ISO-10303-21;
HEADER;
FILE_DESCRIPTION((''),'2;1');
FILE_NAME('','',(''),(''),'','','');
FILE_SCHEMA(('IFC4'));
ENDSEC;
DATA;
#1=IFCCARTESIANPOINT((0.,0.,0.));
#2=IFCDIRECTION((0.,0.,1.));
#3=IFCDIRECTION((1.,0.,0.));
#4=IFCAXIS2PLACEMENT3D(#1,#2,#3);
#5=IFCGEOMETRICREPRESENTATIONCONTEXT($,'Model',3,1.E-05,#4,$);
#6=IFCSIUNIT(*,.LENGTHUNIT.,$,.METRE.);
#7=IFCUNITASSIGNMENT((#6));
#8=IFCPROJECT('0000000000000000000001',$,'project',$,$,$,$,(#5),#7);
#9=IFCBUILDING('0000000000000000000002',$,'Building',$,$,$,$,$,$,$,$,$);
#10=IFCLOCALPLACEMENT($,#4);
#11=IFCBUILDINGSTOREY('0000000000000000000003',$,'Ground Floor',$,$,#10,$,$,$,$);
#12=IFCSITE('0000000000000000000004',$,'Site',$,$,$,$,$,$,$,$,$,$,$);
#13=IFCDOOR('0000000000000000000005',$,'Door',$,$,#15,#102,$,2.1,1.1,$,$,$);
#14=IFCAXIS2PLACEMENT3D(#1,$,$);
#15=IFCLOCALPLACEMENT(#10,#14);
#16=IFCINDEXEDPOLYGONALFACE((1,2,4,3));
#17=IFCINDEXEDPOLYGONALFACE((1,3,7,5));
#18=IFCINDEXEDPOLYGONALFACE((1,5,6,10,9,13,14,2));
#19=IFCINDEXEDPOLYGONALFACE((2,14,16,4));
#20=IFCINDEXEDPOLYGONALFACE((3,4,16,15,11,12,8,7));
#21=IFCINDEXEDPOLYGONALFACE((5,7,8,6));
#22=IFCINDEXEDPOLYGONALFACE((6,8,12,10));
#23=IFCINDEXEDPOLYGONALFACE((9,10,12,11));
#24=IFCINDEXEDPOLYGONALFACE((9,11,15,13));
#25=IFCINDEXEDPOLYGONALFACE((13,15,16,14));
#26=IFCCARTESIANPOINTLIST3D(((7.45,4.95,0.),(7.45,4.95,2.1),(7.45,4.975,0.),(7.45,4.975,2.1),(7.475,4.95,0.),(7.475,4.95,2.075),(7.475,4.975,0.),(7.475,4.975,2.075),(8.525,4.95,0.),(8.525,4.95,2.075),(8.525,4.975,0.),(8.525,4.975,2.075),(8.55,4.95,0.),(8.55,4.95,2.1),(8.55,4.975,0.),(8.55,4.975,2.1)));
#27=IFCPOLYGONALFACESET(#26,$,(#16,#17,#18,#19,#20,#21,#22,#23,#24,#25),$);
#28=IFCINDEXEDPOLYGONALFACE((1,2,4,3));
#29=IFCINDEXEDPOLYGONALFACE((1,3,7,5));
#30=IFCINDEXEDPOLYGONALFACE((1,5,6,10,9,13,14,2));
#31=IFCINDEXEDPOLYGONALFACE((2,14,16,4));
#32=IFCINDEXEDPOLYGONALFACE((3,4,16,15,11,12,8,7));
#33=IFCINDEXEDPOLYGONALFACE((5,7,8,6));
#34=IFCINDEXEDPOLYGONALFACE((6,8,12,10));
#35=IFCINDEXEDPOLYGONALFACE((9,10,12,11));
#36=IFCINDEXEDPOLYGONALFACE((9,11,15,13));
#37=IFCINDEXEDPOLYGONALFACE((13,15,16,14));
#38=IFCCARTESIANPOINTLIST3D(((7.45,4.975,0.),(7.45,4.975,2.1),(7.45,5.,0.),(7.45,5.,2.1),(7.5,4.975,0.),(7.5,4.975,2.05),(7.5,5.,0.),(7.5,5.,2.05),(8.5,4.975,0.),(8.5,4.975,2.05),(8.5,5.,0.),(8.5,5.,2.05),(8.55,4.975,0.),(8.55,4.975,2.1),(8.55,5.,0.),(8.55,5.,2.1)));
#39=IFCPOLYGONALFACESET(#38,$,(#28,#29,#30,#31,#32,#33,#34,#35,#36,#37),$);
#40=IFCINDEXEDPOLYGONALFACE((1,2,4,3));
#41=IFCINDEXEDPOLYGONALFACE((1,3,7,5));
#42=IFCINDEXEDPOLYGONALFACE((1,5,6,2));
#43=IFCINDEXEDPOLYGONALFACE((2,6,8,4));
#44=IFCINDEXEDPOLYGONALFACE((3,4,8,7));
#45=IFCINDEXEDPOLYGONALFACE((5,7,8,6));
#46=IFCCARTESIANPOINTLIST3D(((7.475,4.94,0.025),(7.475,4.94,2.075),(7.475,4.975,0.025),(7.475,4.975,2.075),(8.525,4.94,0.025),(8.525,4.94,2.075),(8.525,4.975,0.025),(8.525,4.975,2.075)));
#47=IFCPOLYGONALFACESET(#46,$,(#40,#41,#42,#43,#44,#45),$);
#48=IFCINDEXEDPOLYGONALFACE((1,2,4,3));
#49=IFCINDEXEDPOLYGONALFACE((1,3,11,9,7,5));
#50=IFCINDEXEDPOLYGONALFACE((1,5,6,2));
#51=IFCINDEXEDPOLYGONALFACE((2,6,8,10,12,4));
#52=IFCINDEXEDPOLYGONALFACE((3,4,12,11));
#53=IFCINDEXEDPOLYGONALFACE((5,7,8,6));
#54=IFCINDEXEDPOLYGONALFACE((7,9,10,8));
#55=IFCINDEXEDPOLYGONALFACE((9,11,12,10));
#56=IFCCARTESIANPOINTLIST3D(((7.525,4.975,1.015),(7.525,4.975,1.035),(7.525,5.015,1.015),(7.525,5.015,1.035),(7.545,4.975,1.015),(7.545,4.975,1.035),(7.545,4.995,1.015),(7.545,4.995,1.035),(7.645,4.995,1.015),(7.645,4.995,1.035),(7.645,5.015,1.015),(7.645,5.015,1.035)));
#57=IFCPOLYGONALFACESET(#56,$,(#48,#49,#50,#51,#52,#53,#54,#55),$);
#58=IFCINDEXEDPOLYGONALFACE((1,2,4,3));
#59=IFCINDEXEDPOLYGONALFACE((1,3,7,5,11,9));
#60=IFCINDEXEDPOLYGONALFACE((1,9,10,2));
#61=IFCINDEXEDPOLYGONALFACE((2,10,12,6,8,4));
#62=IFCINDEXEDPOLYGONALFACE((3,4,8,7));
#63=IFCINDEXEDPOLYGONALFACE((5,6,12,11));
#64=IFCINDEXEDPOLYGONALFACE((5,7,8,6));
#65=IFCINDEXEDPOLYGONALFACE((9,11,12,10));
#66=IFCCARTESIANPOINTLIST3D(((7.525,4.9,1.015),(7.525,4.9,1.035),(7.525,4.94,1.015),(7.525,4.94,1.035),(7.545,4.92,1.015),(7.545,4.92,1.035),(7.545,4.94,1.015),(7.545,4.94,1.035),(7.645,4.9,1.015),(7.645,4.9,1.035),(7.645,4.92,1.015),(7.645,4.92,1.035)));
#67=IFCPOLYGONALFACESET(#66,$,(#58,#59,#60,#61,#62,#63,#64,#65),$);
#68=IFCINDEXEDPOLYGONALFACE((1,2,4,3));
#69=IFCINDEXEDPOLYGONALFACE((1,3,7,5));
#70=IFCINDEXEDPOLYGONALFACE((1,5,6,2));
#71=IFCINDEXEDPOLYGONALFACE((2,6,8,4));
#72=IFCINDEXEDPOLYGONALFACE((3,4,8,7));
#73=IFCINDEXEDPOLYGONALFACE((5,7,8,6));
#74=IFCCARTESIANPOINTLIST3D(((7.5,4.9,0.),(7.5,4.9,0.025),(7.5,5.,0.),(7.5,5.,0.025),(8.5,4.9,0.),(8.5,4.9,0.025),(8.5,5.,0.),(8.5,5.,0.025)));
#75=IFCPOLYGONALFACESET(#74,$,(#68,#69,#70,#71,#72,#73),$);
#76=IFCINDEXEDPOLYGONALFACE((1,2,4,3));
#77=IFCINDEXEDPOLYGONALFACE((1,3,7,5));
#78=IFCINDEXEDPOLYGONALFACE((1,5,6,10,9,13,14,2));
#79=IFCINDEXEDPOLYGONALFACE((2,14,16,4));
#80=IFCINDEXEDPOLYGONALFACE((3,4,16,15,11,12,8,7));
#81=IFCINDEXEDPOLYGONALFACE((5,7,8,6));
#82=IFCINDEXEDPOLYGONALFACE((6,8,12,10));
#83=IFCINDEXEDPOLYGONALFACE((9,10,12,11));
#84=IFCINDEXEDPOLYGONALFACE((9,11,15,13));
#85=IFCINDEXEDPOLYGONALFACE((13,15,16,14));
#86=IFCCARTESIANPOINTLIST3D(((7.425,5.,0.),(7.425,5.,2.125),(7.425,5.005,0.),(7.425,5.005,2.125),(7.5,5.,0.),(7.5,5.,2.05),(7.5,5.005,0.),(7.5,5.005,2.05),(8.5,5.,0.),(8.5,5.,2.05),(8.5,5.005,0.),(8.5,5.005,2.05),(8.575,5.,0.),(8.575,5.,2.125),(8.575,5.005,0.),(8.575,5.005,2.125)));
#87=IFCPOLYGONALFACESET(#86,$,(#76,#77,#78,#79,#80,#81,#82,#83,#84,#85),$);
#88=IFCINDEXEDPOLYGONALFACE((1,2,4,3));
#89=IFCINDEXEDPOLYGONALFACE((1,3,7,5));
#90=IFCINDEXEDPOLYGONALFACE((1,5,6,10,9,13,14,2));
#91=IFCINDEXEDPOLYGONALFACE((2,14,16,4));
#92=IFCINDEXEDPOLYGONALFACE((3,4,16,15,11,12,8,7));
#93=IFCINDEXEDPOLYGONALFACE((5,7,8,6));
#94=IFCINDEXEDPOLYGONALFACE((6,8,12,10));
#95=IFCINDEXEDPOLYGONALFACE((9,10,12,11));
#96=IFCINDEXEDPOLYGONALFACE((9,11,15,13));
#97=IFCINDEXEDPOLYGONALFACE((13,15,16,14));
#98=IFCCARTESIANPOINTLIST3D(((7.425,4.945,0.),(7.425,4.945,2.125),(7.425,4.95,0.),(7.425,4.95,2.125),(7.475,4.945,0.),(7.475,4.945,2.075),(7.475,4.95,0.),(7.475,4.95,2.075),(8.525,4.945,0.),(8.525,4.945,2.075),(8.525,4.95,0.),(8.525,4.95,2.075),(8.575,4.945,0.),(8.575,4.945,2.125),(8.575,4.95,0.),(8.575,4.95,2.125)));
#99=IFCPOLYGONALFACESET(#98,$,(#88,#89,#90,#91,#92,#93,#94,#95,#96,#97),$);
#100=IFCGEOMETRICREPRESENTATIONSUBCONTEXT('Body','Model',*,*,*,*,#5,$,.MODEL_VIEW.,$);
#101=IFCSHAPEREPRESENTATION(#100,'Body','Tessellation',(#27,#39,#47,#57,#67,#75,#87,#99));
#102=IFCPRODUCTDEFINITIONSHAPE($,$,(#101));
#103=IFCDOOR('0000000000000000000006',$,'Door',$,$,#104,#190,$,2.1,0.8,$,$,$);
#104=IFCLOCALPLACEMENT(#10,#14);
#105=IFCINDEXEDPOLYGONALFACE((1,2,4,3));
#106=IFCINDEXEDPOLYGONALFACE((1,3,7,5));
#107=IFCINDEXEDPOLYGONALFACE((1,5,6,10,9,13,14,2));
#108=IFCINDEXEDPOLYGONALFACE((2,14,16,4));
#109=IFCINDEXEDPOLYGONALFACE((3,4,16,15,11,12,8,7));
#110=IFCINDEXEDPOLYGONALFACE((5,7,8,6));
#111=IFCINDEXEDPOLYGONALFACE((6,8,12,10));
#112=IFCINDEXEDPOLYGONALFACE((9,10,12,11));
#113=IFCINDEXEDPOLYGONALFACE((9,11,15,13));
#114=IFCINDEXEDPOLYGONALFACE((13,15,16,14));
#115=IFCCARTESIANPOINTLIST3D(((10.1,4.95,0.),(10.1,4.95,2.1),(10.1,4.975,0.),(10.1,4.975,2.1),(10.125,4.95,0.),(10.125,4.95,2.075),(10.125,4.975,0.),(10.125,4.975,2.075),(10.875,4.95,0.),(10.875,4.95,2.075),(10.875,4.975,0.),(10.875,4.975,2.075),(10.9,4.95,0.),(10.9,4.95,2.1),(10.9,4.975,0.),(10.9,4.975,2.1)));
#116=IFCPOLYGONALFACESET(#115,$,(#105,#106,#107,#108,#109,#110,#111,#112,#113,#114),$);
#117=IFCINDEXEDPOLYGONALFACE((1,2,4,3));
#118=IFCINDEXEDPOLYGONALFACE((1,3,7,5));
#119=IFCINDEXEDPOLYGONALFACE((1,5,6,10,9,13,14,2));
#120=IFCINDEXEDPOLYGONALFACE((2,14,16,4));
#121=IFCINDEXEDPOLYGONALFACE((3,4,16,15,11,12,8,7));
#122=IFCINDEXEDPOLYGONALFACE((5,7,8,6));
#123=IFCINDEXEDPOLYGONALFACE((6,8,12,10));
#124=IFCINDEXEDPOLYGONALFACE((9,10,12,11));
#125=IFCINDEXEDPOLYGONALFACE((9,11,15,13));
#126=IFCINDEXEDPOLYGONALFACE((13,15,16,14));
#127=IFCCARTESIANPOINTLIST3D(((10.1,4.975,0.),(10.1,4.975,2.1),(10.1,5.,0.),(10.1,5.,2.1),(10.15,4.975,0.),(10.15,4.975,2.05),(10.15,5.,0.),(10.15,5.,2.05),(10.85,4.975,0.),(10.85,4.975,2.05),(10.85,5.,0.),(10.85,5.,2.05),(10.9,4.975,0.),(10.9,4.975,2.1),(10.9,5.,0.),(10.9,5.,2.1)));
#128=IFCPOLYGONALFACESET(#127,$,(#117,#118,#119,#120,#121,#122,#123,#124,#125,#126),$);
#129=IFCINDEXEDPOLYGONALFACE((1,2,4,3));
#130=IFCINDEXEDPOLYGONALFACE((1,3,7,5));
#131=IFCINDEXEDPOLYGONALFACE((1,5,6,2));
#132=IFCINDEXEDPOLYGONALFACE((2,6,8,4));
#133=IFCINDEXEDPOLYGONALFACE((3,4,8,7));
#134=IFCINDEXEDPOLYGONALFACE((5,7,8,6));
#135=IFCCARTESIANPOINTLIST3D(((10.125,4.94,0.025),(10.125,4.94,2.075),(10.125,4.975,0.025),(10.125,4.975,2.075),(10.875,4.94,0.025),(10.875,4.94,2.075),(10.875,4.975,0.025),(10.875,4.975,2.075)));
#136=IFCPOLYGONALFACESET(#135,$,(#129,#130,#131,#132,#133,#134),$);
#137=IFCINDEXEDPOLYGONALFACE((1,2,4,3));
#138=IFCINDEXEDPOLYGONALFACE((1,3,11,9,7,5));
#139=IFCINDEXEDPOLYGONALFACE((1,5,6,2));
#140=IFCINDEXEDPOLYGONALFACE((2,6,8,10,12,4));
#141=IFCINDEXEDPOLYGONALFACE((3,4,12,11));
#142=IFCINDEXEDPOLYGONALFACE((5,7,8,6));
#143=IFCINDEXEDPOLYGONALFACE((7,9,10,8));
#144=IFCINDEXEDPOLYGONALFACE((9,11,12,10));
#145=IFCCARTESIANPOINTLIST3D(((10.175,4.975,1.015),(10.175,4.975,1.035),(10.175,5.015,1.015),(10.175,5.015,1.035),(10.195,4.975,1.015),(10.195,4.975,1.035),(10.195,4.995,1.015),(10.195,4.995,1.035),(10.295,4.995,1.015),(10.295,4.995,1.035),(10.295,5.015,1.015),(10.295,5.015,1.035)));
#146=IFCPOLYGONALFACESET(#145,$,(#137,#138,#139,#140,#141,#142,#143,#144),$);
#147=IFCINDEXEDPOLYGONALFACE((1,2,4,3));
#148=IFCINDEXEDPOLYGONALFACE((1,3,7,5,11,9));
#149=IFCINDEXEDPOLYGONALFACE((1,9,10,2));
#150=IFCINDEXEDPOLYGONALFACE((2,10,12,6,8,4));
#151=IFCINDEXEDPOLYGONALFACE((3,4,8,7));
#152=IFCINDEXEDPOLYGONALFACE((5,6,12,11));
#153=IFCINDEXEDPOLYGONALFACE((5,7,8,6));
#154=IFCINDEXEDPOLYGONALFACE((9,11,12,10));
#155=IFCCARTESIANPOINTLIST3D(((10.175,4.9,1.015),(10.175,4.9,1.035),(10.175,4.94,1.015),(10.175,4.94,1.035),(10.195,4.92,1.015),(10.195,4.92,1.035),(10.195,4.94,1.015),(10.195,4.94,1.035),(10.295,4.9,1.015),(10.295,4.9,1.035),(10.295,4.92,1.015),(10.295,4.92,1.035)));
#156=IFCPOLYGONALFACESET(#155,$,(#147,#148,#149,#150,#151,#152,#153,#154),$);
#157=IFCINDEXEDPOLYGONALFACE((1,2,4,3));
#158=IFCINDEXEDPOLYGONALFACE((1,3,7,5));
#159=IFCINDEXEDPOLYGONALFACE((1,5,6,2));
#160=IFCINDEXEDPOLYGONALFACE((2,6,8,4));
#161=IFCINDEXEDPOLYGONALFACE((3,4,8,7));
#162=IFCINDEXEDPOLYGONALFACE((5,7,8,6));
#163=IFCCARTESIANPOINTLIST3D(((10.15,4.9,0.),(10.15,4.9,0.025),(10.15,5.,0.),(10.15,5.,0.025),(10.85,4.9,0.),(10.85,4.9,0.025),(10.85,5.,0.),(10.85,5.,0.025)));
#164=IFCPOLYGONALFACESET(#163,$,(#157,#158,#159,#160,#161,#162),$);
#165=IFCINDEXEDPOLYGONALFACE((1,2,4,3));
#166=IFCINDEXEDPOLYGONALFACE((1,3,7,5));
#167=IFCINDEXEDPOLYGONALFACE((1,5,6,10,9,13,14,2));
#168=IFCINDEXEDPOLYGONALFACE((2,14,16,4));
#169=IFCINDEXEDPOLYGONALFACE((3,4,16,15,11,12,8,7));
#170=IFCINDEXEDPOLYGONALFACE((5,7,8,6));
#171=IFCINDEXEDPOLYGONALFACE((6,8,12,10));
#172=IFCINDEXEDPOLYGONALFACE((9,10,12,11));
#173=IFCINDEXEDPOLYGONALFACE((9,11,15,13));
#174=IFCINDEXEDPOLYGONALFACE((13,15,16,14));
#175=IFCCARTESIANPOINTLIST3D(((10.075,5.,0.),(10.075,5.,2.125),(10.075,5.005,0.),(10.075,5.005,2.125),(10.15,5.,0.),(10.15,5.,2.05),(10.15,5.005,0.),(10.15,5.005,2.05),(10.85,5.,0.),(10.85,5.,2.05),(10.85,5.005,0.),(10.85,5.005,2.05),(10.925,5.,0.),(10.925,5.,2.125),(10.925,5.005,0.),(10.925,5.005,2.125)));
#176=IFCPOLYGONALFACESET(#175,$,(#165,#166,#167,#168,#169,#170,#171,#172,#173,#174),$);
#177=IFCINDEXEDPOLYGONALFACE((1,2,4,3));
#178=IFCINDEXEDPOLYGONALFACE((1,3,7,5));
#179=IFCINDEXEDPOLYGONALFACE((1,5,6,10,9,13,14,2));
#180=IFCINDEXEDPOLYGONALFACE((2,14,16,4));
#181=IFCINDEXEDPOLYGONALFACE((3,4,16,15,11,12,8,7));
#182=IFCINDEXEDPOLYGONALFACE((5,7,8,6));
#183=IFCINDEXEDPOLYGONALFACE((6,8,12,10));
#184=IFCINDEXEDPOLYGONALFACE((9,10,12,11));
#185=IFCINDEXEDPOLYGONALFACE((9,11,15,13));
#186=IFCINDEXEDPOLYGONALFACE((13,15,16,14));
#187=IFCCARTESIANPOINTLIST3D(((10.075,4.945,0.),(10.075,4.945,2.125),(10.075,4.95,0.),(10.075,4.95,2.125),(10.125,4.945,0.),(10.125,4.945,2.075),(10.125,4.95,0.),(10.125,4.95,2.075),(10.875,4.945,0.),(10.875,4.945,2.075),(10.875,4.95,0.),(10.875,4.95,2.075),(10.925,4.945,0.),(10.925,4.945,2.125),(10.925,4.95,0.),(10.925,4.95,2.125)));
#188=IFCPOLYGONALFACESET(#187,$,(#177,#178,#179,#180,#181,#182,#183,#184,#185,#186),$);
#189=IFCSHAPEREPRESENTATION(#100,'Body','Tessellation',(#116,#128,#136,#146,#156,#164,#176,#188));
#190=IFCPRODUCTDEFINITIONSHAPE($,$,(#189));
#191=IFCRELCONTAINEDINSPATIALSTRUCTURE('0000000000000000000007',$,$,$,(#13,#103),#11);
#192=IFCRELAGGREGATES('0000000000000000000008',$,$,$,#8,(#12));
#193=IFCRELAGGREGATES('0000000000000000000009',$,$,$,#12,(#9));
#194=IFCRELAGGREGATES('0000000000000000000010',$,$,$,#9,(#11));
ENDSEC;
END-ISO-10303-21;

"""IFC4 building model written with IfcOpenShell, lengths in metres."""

from ifc_helpers import new_model, si_unit, frame, origin_with_axes, place, context, subcontext, project, spatial, line, indexed_curve, outline, extrude, element, save


model = new_model("IFC4")

# Units and contexts
model_context = context("Model", 3, precision=1e-05, world=origin_with_axes())
body_context = subcontext(model_context, "Body", "Model", "MODEL_VIEW")
ifc_project = project(units=[si_unit("LENGTHUNIT", "METRE")], contexts=[model_context])

# Site, building, storey
site = spatial("IfcSite", under=ifc_project, Name="Site")
building = spatial("IfcBuilding", under=site, Name="Building")
storey_placement = place(None, origin_with_axes())
storey = spatial("IfcBuildingStorey", under=building, at=storey_placement, Name="Ground Floor")

# Doors
door_1_placement = place(storey_placement, frame((8.55, 5.0, 0.0), z_axis=(0.0, 0.0, 1.0), x_axis=(-1.0, 0.0, 0.0)))
element("IfcDoor", 1, at=door_1_placement, inside=storey, Name="Door", OverallHeight=2.1, OverallWidth=1.1, context=body_context, shape_type="SweptSolid", body=[
    extrude(outline(indexed_curve([(0.0, 0.0), (0.0, 2.1), (1.1, 2.1), (1.1, 0.0), (1.075, 0.0), (1.075, 2.075), (0.025, 2.075), (0.025, 0.0)], segments=[line(1, 2, 3, 4, 5, 6, 7, 8, 1)])), frame((0.0, 0.025, 0.0), z_axis=(0.0, -1.0, 0.0), x_axis=(1.0, 0.0, 0.0)), (0.0, 0.0, -1.0), 0.025),
    extrude(outline(indexed_curve([(0.0, 0.0), (0.0, 2.1), (1.1, 2.1), (1.1, 0.0), (1.05, 0.0), (1.05, 2.05), (0.05, 2.05), (0.05, 0.0)], segments=[line(1, 2, 3, 4, 5, 6, 7, 8, 1)])), frame((0.0, 0.0, 0.0), z_axis=(0.0, -1.0, 0.0), x_axis=(1.0, 0.0, 0.0)), (0.0, 0.0, -1.0), 0.025),
    extrude(outline(indexed_curve([(0.0, 0.0), (1.05, 0.0), (1.05, 0.035), (0.0, 0.035)], segments=[line(1, 2, 3, 4, 1)])), frame((0.025, 0.025, 0.025), z_axis=(0.0, 0.0, 1.0), x_axis=(1.0, 0.0, 0.0)), (0.0, 0.0, 1.0), 2.05),
    extrude(outline(indexed_curve([(0.0, 0.0), (0.0, -0.04), (-0.12, -0.04), (-0.12, -0.02), (-0.02, -0.02), (-0.02, 0.0)], segments=[line(1, 2, 3, 4, 5, 6, 1)])), frame((1.025, 0.025, 1.015), z_axis=(0.0, 0.0, 1.0), x_axis=(1.0, 0.0, 0.0)), (0.0, 0.0, 1.0), 0.02),
    extrude(outline(indexed_curve([(0.0, 0.0), (0.0, 0.04), (-0.12, 0.04), (-0.12, 0.02), (-0.02, 0.02), (-0.02, 0.0)], segments=[line(1, 2, 3, 4, 5, 6, 1)])), frame((1.025, 0.06, 1.015), z_axis=(0.0, 0.0, 1.0), x_axis=(1.0, 0.0, 0.0)), (0.0, 0.0, 1.0), 0.02),
    extrude(outline(indexed_curve([(0.0, 0.0), (1.0, 0.0), (1.0, 0.1), (0.0, 0.1)], segments=[line(1, 2, 3, 4, 1)])), frame((0.05, 0.0, 0.0), z_axis=(0.0, 0.0, 1.0), x_axis=(1.0, 0.0, 0.0)), (0.0, 0.0, 1.0), 0.025),
    extrude(outline(indexed_curve([(0.0, 0.0), (0.0, 2.125), (1.15, 2.125), (1.15, 0.0), (1.075, 0.0), (1.075, 2.05), (0.075, 2.05), (0.075, 0.0)], segments=[line(1, 2, 3, 4, 5, 6, 7, 8, 1)])), frame((-0.025, -0.005, 0.0), z_axis=(0.0, -1.0, 0.0), x_axis=(1.0, 0.0, 0.0)), (0.0, 0.0, -1.0), 0.005),
    extrude(outline(indexed_curve([(0.0, 0.0), (0.0, 2.125), (1.15, 2.125), (1.15, 0.0), (1.1, 0.0), (1.1, 2.075), (0.05, 2.075), (0.05, 0.0)], segments=[line(1, 2, 3, 4, 5, 6, 7, 8, 1)])), frame((-0.025, 0.05, 0.0), z_axis=(0.0, -1.0, 0.0), x_axis=(1.0, 0.0, 0.0)), (0.0, 0.0, -1.0), 0.005),
])
door_2_placement = place(storey_placement, frame((10.9, 5.0, 0.0), z_axis=(0.0, 0.0, 1.0), x_axis=(-1.0, 0.0, 0.0)))
element("IfcDoor", 2, at=door_2_placement, inside=storey, Name="Door", OverallHeight=2.1, OverallWidth=0.8, context=body_context, shape_type="SweptSolid", body=[
    extrude(outline(indexed_curve([(0.0, 0.0), (0.0, 2.1), (0.8, 2.1), (0.8, 0.0), (0.775, 0.0), (0.775, 2.075), (0.025, 2.075), (0.025, 0.0)], segments=[line(1, 2, 3, 4, 5, 6, 7, 8, 1)])), frame((0.0, 0.025, 0.0), z_axis=(0.0, -1.0, 0.0), x_axis=(1.0, 0.0, 0.0)), (0.0, 0.0, -1.0), 0.025),
    extrude(outline(indexed_curve([(0.0, 0.0), (0.0, 2.1), (0.8, 2.1), (0.8, 0.0), (0.75, 0.0), (0.75, 2.05), (0.05, 2.05), (0.05, 0.0)], segments=[line(1, 2, 3, 4, 5, 6, 7, 8, 1)])), frame((0.0, 0.0, 0.0), z_axis=(0.0, -1.0, 0.0), x_axis=(1.0, 0.0, 0.0)), (0.0, 0.0, -1.0), 0.025),
    extrude(outline(indexed_curve([(0.0, 0.0), (0.75, 0.0), (0.75, 0.035), (0.0, 0.035)], segments=[line(1, 2, 3, 4, 1)])), frame((0.025, 0.025, 0.025), z_axis=(0.0, 0.0, 1.0), x_axis=(1.0, 0.0, 0.0)), (0.0, 0.0, 1.0), 2.05),
    extrude(outline(indexed_curve([(0.0, 0.0), (0.0, -0.04), (-0.12, -0.04), (-0.12, -0.02), (-0.02, -0.02), (-0.02, 0.0)], segments=[line(1, 2, 3, 4, 5, 6, 1)])), frame((0.725, 0.025, 1.015), z_axis=(0.0, 0.0, 1.0), x_axis=(1.0, 0.0, 0.0)), (0.0, 0.0, 1.0), 0.02),
    extrude(outline(indexed_curve([(0.0, 0.0), (0.0, 0.04), (-0.12, 0.04), (-0.12, 0.02), (-0.02, 0.02), (-0.02, 0.0)], segments=[line(1, 2, 3, 4, 5, 6, 1)])), frame((0.725, 0.06, 1.015), z_axis=(0.0, 0.0, 1.0), x_axis=(1.0, 0.0, 0.0)), (0.0, 0.0, 1.0), 0.02),
    extrude(outline(indexed_curve([(0.0, 0.0), (0.7, 0.0), (0.7, 0.1), (0.0, 0.1)], segments=[line(1, 2, 3, 4, 1)])), frame((0.05, 0.0, 0.0), z_axis=(0.0, 0.0, 1.0), x_axis=(1.0, 0.0, 0.0)), (0.0, 0.0, 1.0), 0.025),
    extrude(outline(indexed_curve([(0.0, 0.0), (0.0, 2.125), (0.85, 2.125), (0.85, 0.0), (0.775, 0.0), (0.775, 2.05), (0.075, 2.05), (0.075, 0.0)], segments=[line(1, 2, 3, 4, 5, 6, 7, 8, 1)])), frame((-0.025, -0.005, 0.0), z_axis=(0.0, -1.0, 0.0), x_axis=(1.0, 0.0, 0.0)), (0.0, 0.0, -1.0), 0.005),
    extrude(outline(indexed_curve([(0.0, 0.0), (0.0, 2.125), (0.85, 2.125), (0.85, 0.0), (0.8, 0.0), (0.8, 2.075), (0.05, 2.075), (0.05, 0.0)], segments=[line(1, 2, 3, 4, 5, 6, 7, 8, 1)])), frame((-0.025, 0.05, 0.0), z_axis=(0.0, -1.0, 0.0), x_axis=(1.0, 0.0, 0.0)), (0.0, 0.0, -1.0), 0.005),
])

save(model, "model.ifc")
